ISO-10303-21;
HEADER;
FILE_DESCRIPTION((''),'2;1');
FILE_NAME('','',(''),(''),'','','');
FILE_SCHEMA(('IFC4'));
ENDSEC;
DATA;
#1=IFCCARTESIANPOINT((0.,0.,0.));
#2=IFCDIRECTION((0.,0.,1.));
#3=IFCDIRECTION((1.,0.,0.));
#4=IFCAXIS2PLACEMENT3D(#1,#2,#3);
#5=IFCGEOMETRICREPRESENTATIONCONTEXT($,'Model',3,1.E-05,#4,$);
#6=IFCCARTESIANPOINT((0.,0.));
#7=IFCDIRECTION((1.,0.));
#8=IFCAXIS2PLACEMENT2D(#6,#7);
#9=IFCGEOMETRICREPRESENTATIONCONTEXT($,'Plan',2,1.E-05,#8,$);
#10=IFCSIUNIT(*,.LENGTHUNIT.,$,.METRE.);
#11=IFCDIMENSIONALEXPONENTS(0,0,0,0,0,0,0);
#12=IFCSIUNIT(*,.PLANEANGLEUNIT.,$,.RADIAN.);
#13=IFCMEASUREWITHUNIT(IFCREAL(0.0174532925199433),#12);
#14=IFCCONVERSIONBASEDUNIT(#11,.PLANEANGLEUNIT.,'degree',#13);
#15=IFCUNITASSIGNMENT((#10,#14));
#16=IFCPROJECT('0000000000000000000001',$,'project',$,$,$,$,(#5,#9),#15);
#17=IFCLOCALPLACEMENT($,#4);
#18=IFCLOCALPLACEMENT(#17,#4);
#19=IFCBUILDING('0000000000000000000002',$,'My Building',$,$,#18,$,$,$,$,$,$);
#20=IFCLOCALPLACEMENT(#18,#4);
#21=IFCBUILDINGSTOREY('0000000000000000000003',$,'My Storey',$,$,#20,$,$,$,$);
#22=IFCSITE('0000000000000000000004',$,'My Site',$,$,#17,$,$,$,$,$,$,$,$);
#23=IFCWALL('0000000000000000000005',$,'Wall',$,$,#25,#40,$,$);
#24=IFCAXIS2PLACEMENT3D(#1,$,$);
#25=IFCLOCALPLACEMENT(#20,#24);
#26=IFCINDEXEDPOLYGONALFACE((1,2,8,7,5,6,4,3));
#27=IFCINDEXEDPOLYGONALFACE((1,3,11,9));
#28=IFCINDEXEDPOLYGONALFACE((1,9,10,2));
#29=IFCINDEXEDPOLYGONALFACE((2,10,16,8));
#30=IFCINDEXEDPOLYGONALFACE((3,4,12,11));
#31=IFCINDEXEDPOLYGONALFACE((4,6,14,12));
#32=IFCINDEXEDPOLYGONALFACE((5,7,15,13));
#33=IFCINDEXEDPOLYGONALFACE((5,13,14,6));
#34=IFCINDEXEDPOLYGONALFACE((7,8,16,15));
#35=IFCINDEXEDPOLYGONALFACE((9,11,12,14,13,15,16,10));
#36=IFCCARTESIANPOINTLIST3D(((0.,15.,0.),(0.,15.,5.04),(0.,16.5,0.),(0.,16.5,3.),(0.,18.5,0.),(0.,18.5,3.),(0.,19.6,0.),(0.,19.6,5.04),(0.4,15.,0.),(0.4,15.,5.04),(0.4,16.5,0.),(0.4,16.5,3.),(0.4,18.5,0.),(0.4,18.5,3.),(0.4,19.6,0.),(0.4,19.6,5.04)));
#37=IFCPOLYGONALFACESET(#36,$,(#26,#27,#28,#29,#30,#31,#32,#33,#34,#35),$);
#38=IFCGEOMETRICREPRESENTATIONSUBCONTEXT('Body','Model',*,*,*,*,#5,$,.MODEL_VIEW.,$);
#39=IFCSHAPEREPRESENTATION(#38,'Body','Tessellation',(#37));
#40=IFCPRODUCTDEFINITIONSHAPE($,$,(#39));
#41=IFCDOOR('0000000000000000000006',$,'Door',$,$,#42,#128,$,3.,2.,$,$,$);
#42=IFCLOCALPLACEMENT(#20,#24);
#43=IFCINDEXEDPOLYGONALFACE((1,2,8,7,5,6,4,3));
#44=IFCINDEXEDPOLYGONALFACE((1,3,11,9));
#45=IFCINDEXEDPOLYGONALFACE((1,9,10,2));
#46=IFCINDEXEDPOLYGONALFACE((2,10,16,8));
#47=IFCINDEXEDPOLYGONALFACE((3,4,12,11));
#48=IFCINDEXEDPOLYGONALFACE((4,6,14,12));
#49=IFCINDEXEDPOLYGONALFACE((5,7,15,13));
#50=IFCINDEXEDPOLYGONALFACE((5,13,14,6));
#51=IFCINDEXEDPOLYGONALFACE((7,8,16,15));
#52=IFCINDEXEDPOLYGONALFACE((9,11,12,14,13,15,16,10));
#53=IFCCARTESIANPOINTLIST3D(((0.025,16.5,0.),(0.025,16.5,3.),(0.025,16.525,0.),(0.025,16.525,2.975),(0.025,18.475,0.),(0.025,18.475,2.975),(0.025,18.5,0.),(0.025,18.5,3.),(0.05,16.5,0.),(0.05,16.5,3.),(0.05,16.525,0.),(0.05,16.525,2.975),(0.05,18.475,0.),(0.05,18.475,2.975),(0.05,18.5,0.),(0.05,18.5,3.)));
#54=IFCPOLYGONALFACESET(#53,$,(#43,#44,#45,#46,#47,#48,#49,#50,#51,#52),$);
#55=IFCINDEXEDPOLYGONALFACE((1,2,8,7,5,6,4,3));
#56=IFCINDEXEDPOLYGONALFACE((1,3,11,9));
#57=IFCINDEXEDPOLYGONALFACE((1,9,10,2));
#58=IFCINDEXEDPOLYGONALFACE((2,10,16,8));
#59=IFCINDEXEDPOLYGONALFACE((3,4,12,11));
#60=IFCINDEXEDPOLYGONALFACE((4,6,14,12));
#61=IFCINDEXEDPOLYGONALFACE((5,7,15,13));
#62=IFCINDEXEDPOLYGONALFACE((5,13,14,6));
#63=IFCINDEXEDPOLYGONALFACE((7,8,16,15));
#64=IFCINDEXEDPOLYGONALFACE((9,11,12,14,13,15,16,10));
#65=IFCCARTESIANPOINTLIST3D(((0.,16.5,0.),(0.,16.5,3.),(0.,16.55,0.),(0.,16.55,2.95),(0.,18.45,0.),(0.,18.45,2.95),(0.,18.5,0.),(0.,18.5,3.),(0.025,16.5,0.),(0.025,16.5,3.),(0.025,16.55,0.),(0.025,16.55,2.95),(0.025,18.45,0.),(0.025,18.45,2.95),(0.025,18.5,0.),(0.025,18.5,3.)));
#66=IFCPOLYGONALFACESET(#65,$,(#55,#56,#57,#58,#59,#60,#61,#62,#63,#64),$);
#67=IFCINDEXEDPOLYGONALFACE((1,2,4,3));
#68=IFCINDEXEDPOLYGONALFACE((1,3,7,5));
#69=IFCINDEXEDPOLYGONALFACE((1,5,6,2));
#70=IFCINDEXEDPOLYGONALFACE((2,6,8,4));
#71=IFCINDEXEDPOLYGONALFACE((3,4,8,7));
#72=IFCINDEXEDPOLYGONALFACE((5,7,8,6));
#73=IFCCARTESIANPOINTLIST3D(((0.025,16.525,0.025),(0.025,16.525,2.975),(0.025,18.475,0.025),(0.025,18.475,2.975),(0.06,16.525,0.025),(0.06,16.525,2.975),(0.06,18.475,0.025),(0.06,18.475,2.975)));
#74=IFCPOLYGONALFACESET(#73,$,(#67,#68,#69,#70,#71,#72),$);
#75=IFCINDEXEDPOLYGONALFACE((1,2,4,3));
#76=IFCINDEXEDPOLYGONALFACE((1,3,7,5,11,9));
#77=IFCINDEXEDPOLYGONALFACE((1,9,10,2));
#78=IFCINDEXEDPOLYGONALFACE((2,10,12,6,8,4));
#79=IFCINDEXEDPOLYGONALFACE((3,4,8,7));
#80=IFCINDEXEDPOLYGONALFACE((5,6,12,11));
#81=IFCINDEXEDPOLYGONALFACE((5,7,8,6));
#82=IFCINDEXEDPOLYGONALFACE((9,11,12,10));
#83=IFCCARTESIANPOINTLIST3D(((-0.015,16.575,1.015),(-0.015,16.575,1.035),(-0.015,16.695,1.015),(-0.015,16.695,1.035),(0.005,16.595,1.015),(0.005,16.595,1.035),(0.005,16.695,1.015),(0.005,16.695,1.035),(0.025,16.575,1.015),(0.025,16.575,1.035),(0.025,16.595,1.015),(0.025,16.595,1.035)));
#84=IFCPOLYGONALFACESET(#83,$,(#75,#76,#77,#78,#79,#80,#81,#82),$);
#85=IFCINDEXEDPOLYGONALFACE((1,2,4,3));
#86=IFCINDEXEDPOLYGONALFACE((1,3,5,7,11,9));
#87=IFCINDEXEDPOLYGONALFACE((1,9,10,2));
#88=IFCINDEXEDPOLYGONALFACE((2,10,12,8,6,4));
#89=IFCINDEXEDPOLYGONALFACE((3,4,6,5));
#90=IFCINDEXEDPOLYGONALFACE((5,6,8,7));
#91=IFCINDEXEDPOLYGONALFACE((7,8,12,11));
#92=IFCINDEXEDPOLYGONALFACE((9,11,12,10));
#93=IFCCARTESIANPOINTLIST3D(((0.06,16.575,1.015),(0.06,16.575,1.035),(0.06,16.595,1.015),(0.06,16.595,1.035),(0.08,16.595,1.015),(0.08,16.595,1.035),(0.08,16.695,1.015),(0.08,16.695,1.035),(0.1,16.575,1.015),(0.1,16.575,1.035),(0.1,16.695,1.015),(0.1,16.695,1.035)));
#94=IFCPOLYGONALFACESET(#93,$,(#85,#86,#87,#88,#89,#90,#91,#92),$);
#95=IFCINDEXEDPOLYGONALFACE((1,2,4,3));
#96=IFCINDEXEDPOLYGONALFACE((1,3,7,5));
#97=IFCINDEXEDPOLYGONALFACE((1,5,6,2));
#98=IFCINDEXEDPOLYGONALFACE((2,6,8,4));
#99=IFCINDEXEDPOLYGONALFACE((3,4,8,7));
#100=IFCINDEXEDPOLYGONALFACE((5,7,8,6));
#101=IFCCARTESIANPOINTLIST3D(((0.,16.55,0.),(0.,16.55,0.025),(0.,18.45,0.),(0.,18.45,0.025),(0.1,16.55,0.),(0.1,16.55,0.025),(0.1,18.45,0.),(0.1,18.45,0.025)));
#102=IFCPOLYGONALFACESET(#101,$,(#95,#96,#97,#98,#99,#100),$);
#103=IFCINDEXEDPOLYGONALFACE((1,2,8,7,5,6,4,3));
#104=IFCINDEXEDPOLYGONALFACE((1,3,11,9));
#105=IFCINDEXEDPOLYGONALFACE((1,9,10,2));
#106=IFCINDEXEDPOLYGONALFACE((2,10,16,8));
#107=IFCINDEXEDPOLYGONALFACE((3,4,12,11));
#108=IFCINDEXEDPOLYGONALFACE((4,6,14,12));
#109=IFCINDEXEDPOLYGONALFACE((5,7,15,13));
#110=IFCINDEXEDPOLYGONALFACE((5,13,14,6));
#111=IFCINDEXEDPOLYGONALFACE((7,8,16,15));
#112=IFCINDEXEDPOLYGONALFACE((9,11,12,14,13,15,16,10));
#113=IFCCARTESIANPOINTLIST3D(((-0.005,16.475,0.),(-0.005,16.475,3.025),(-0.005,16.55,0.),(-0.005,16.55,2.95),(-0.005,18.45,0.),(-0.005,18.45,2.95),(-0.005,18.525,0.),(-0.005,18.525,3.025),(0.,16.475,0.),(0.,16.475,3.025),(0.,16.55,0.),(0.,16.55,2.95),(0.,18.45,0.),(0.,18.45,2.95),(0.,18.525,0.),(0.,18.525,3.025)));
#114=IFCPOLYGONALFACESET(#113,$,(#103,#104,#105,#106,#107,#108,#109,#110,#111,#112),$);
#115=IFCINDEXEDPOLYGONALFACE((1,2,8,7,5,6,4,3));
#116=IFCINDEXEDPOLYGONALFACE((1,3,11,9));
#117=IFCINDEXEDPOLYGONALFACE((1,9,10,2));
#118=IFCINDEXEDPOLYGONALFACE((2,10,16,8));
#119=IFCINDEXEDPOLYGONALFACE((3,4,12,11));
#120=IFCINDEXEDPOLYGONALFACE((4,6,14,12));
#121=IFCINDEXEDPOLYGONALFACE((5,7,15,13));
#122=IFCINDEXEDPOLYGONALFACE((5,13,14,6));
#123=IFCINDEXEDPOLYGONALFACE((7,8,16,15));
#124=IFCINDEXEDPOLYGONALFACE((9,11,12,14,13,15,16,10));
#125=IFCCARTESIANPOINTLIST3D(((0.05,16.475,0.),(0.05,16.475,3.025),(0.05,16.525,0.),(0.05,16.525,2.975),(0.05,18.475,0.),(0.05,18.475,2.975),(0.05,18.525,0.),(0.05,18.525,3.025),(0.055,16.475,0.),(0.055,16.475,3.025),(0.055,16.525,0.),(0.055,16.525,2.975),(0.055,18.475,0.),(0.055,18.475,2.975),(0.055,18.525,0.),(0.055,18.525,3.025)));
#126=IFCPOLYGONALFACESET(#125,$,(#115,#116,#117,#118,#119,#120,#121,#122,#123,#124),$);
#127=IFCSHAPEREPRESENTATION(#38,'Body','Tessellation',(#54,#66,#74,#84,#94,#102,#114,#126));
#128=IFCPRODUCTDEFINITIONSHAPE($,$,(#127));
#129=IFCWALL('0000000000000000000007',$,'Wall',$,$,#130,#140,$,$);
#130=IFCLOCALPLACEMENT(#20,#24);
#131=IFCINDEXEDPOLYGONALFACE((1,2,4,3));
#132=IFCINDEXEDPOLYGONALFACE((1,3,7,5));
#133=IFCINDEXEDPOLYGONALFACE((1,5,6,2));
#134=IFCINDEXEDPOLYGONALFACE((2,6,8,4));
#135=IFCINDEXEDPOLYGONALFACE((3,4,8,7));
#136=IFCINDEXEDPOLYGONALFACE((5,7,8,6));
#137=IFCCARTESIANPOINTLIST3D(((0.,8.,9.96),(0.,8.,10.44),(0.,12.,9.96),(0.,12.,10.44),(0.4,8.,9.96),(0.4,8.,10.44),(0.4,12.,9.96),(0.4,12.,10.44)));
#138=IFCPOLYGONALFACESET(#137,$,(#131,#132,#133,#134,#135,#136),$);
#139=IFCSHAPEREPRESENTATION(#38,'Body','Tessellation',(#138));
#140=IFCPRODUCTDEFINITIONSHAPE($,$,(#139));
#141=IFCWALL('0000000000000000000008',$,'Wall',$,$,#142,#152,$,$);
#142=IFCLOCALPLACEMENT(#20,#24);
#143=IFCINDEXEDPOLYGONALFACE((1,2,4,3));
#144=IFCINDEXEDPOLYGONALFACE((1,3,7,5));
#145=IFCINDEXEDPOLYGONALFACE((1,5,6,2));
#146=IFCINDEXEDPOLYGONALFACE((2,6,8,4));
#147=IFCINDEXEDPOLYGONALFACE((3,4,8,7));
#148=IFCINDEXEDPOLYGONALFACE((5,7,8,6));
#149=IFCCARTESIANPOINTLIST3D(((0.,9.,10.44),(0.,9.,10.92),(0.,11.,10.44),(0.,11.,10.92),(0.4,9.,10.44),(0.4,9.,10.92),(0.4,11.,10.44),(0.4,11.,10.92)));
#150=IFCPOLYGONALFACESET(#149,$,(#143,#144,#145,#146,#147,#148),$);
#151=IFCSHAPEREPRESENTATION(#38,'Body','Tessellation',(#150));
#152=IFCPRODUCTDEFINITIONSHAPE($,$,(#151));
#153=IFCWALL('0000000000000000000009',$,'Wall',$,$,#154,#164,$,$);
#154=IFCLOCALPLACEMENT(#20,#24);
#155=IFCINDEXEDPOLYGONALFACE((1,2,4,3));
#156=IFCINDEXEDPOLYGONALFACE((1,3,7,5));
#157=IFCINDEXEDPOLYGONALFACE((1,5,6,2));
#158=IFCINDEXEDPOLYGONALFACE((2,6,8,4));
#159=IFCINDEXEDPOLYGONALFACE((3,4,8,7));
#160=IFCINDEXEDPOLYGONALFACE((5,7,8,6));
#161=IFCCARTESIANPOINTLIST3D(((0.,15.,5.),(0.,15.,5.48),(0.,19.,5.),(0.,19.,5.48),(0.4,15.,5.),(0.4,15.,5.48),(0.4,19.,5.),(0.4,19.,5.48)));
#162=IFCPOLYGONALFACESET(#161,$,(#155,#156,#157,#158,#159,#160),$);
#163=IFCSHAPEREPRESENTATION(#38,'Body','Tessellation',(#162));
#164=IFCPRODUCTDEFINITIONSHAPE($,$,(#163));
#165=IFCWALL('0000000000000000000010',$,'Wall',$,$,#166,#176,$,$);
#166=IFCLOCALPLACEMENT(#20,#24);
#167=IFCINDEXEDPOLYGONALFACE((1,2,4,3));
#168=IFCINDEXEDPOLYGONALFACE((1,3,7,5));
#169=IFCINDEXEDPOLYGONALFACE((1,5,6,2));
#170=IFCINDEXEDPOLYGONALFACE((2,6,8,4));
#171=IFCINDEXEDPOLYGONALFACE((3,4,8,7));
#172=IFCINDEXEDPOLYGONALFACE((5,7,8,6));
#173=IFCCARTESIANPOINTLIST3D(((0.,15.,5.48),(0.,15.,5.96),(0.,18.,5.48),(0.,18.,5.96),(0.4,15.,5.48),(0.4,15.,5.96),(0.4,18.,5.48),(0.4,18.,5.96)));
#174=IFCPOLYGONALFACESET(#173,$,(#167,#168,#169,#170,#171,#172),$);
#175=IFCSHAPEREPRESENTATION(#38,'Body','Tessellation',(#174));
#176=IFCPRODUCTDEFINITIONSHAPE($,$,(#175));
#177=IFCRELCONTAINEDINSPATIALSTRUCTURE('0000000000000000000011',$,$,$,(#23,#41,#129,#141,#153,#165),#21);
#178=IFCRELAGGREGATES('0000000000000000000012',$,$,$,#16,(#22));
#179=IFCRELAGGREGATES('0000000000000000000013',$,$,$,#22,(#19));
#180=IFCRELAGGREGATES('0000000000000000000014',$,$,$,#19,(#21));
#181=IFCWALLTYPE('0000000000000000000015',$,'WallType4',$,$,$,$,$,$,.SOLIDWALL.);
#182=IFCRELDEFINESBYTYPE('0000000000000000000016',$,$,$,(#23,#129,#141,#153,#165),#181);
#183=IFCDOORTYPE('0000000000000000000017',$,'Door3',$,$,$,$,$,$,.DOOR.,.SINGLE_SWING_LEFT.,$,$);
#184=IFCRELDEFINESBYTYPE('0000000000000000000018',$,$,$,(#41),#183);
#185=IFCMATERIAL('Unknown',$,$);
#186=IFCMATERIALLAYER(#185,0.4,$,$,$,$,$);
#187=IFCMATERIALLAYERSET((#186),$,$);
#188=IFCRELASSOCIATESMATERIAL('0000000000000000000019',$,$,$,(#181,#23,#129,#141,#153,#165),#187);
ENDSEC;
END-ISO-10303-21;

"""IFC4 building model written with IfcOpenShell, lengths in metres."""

from ifc_helpers import new_model, entity, si_unit, converted_unit, frame, origin_with_axes, origin_2d_with_axis, place, context, subcontext, project, spatial, line, indexed_curve, outline, extrude, shape, source, transform, mapped, material, layer, layer_set, layer_usage, type_object, type_shapes, element, fill, save


model = new_model("IFC4")

# Units and contexts
model_context = context("Model", 3, precision=1e-05, world=origin_with_axes())
plan_context = context("Plan", 2, precision=1e-05, world=origin_2d_with_axis())
body_context_1 = subcontext(model_context, "Body", "Model", "MODEL_VIEW")
body_context_2 = subcontext(plan_context, "Body", "Plan", "PLAN_VIEW")
ifc_project = project(units=[si_unit("LENGTHUNIT", "METRE"), converted_unit("PLANEANGLEUNIT", "degree", entity("IfcReal", 0.0174532925199433), si_unit("PLANEANGLEUNIT", "RADIAN"), dimensions=[0, 0, 0, 0, 0, 0, 0])], contexts=[model_context, plan_context])

# Site, building, storey
site_placement = place(None, origin_with_axes())
site = spatial("IfcSite", under=ifc_project, at=site_placement, Name="My Site")
building_placement = place(site_placement, origin_with_axes())
building = spatial("IfcBuilding", under=site, at=building_placement, Name="My Building")
storey_placement = place(building_placement, origin_with_axes())
storey = spatial("IfcBuildingStorey", under=building, at=storey_placement, Name="My Storey")

# Shared definitions
ifc_material = material(Name="Unknown")

# Shared definitions
ifc_layer_1 = layer(ifc_material, 0.4)
ifc_layer_set_1 = layer_set([ifc_layer_1])
wall_type_1 = type_object("IfcWallType", Name="WallType4", PredefinedType="SOLIDWALL", material=ifc_layer_set_1)

# Wall, opening, door
ifc_layer_usage_1 = layer_usage(ifc_layer_set_1, "AXIS2", "POSITIVE", 0.0)
wall_1_placement = place(storey_placement, frame((0.0, 19.6, 0.0), z_axis=(0.0, 0.0, 1.0), x_axis=(0.0, -1.0, 0.0)))
wall_1 = element("IfcWall", 1, at=wall_1_placement, inside=storey, type_object=wall_type_1, material=ifc_layer_usage_1, Name="Wall", context=body_context_1, shape_type="SweptSolid", body=[
    extrude(outline(indexed_curve([(0.0, 0.0), (0.0, 0.4), (4.6, 0.4), (4.6, 0.0), (0.0, 0.0)], self_intersect=False)), origin_with_axes(), (0.0, 0.0, 1.0), 5.04),
])
shared_shape_1 = source(origin_with_axes(), body_context_1, "Body", "SweptSolid", [
    extrude(outline(indexed_curve([(0.0, 0.0), (2.0, 0.0), (2.0, 3.0), (0.0, 3.0)], segments=[line(1, 2, 3, 4, 1)])), frame((0.0, -0.6, 0.0), z_axis=(0.0, -1.0, 0.0), x_axis=(1.0, 0.0, 0.0)), (0.0, 0.0, -1.0), 1.2),
])
opening_1_placement = place(wall_1_placement, frame((1.1, 0.0, 0.0), z_axis=(0.0, 0.0, 1.0), x_axis=(1.0, 0.0, 0.0)))
opening_1 = element("IfcOpeningElement", 2, at=opening_1_placement, cuts=wall_1, PredefinedType="OPENING", context=body_context_1, shape_type="MappedRepresentation", body=[
    mapped(shared_shape_1, transform((0.0, 0.0, 0.0), x_axis=(1.0, 0.0, 0.0), y_axis=(0.0, 1.0, 0.0), z_axis=(0.0, 0.0, 1.0), scale=1.0)),
])
door_type_1 = type_object("IfcDoorType", Name="Door3", OperationType="SINGLE_SWING_LEFT", PredefinedType="DOOR")
shared_shape_2 = source(origin_with_axes(), body_context_1, "Body", "SweptSolid", [
    extrude(outline(indexed_curve([(0.0, 0.0), (0.0, 3.0), (2.0, 3.0), (2.0, 0.0), (1.975, 0.0), (1.975, 2.975), (0.025, 2.975), (0.025, 0.0)], segments=[line(1, 2, 3, 4, 5, 6, 7, 8, 1)])), frame((0.0, 0.025, 0.0), z_axis=(0.0, -1.0, 0.0), x_axis=(1.0, 0.0, 0.0)), (0.0, 0.0, -1.0), 0.025),
    extrude(outline(indexed_curve([(0.0, 0.0), (0.0, 3.0), (2.0, 3.0), (2.0, 0.0), (1.95, 0.0), (1.95, 2.95), (0.05, 2.95), (0.05, 0.0)], segments=[line(1, 2, 3, 4, 5, 6, 7, 8, 1)])), frame((0.0, 0.0, 0.0), z_axis=(0.0, -1.0, 0.0), x_axis=(1.0, 0.0, 0.0)), (0.0, 0.0, -1.0), 0.025),
    extrude(outline(indexed_curve([(0.0, 0.0), (1.95, 0.0), (1.95, 0.035), (0.0, 0.035)], segments=[line(1, 2, 3, 4, 1)])), frame((0.025, 0.025, 0.025), z_axis=(0.0, 0.0, 1.0), x_axis=(1.0, 0.0, 0.0)), (0.0, 0.0, 1.0), 2.95),
    extrude(outline(indexed_curve([(0.0, 0.0), (0.0, -0.04), (-0.12, -0.04), (-0.12, -0.02), (-0.02, -0.02), (-0.02, 0.0)], segments=[line(1, 2, 3, 4, 5, 6, 1)])), frame((1.925, 0.025, 1.015), z_axis=(0.0, 0.0, 1.0), x_axis=(1.0, 0.0, 0.0)), (0.0, 0.0, 1.0), 0.02),
    extrude(outline(indexed_curve([(0.0, 0.0), (0.0, 0.04), (-0.12, 0.04), (-0.12, 0.02), (-0.02, 0.02), (-0.02, 0.0)], segments=[line(1, 2, 3, 4, 5, 6, 1)])), frame((1.925, 0.06, 1.015), z_axis=(0.0, 0.0, 1.0), x_axis=(1.0, 0.0, 0.0)), (0.0, 0.0, 1.0), 0.02),
    extrude(outline(indexed_curve([(0.0, 0.0), (1.9, 0.0), (1.9, 0.1), (0.0, 0.1)], segments=[line(1, 2, 3, 4, 1)])), frame((0.05, 0.0, 0.0), z_axis=(0.0, 0.0, 1.0), x_axis=(1.0, 0.0, 0.0)), (0.0, 0.0, 1.0), 0.025),
    extrude(outline(indexed_curve([(0.0, 0.0), (0.0, 3.025), (2.05, 3.025), (2.05, 0.0), (1.975, 0.0), (1.975, 2.95), (0.075, 2.95), (0.075, 0.0)], segments=[line(1, 2, 3, 4, 5, 6, 7, 8, 1)])), frame((-0.025, -0.005, 0.0), z_axis=(0.0, -1.0, 0.0), x_axis=(1.0, 0.0, 0.0)), (0.0, 0.0, -1.0), 0.005),
    extrude(outline(indexed_curve([(0.0, 0.0), (0.0, 3.025), (2.05, 3.025), (2.05, 0.0), (2.0, 0.0), (2.0, 2.975), (0.05, 2.975), (0.05, 0.0)], segments=[line(1, 2, 3, 4, 5, 6, 7, 8, 1)])), frame((-0.025, 0.05, 0.0), z_axis=(0.0, -1.0, 0.0), x_axis=(1.0, 0.0, 0.0)), (0.0, 0.0, -1.0), 0.005),
])
shared_shape_3 = source(origin_with_axes(), body_context_2, "Body", "Curve2D", [
    entity("IfcIndexedPolyCurve", entity("IfcCartesianPointList2D", [[0.0, 0.0], [0.0, 0.05], [0.025, 0.05], [0.025, 0.025], [0.05, 0.025], [0.05, 0.0]]), [entity("IfcLineIndex", [1, 2, 3, 4, 5, 6, 1])]),
    entity("IfcIndexedPolyCurve", entity("IfcCartesianPointList2D", [[2.0, 0.0], [2.0, 0.05], [1.975, 0.05], [1.975, 0.025], [1.95, 0.025], [1.95, 0.0]]), [entity("IfcLineIndex", [1, 2, 3, 4, 5, 6, 1])]),
    entity("IfcTrimmedCurve", entity("IfcEllipse", entity("IfcAxis2Placement2D", entity("IfcCartesianPoint", [0.06, 0.05]), entity("IfcDirection", [1.0, 0.0])), 1.915, 1.95), [entity("IfcCartesianPoint", [1.975, 0.05])], [entity("IfcCartesianPoint", [0.06, 2.0])], True, "CARTESIAN"),
    entity("IfcIndexedPolyCurve", entity("IfcCartesianPointList2D", [[0.025, 0.05], [0.06, 0.05], [0.06, 2.0], [0.025, 2.0]]), [entity("IfcLineIndex", [1, 2, 3, 4, 1])]),
])
type_shapes(door_type_1, [shared_shape_2, shared_shape_3])
door_1_placement = place(opening_1_placement, origin_with_axes())
door_1 = element("IfcDoor", 3, at=door_1_placement, inside=storey, type_object=door_type_1, Name="Door", OverallHeight=3.0, OverallWidth=2.0, shapes=[
    shape(body_context_1, "Body", "MappedRepresentation", [mapped(shared_shape_2, transform((0.0, 0.0, 0.0), x_axis=(1.0, 0.0, 0.0), y_axis=(0.0, 1.0, 0.0), z_axis=(0.0, 0.0, 1.0), scale=1.0))]),
    shape(body_context_2, "Body", "MappedRepresentation", [mapped(shared_shape_3, transform((0.0, 0.0, 0.0), x_axis=(1.0, 0.0, 0.0), y_axis=(0.0, 1.0, 0.0), z_axis=(0.0, 0.0, 1.0), scale=1.0))]),
])
fill(opening_1, door_1)

# Walls
ifc_layer_usage_2 = layer_usage(ifc_layer_set_1, "AXIS2", "POSITIVE", 0.0)
wall_2_placement = place(storey_placement, frame((0.4, 8.0, 9.96), z_axis=(0.0, 0.0, 1.0), x_axis=(0.0, 1.0, 0.0)))
element("IfcWall", 4, at=wall_2_placement, inside=storey, type_object=wall_type_1, material=ifc_layer_usage_2, Name="Wall", context=body_context_1, shape_type="SweptSolid", body=[
    extrude(outline(indexed_curve([(0.0, 0.0), (0.0, 0.4), (4.0, 0.4), (4.0, 0.0), (0.0, 0.0)], self_intersect=False)), origin_with_axes(), (0.0, 0.0, 1.0), 0.48),
])
ifc_layer_usage_3 = layer_usage(ifc_layer_set_1, "AXIS2", "POSITIVE", 0.0)
wall_3_placement = place(storey_placement, frame((0.4, 9.0, 10.44), z_axis=(0.0, 0.0, 1.0), x_axis=(0.0, 1.0, 0.0)))
element("IfcWall", 5, at=wall_3_placement, inside=storey, type_object=wall_type_1, material=ifc_layer_usage_3, Name="Wall", context=body_context_1, shape_type="SweptSolid", body=[
    extrude(outline(indexed_curve([(0.0, 0.0), (0.0, 0.4), (2.0, 0.4), (2.0, 0.0), (0.0, 0.0)], self_intersect=False)), origin_with_axes(), (0.0, 0.0, 1.0), 0.48),
])
ifc_layer_usage_4 = layer_usage(ifc_layer_set_1, "AXIS2", "POSITIVE", 0.0)
wall_4_placement = place(storey_placement, frame((0.4, 15.0, 5.0), z_axis=(0.0, 0.0, 1.0), x_axis=(0.0, 1.0, 0.0)))
element("IfcWall", 6, at=wall_4_placement, inside=storey, type_object=wall_type_1, material=ifc_layer_usage_4, Name="Wall", context=body_context_1, shape_type="SweptSolid", body=[
    extrude(outline(indexed_curve([(0.0, 0.0), (0.0, 0.4), (4.0, 0.4), (4.0, 0.0), (0.0, 0.0)], self_intersect=False)), origin_with_axes(), (0.0, 0.0, 1.0), 0.48),
])
ifc_layer_usage_5 = layer_usage(ifc_layer_set_1, "AXIS2", "POSITIVE", 0.0)
wall_5_placement = place(storey_placement, frame((0.4, 15.0, 5.48), z_axis=(0.0, 0.0, 1.0), x_axis=(0.0, 1.0, 0.0)))
element("IfcWall", 7, at=wall_5_placement, inside=storey, type_object=wall_type_1, material=ifc_layer_usage_5, Name="Wall", context=body_context_1, shape_type="SweptSolid", body=[
    extrude(outline(indexed_curve([(0.0, 0.0), (0.0, 0.4), (3.0, 0.4), (3.0, 0.0), (0.0, 0.0)], self_intersect=False)), origin_with_axes(), (0.0, 0.0, 1.0), 0.48),
])

save(model, "model.ifc")
